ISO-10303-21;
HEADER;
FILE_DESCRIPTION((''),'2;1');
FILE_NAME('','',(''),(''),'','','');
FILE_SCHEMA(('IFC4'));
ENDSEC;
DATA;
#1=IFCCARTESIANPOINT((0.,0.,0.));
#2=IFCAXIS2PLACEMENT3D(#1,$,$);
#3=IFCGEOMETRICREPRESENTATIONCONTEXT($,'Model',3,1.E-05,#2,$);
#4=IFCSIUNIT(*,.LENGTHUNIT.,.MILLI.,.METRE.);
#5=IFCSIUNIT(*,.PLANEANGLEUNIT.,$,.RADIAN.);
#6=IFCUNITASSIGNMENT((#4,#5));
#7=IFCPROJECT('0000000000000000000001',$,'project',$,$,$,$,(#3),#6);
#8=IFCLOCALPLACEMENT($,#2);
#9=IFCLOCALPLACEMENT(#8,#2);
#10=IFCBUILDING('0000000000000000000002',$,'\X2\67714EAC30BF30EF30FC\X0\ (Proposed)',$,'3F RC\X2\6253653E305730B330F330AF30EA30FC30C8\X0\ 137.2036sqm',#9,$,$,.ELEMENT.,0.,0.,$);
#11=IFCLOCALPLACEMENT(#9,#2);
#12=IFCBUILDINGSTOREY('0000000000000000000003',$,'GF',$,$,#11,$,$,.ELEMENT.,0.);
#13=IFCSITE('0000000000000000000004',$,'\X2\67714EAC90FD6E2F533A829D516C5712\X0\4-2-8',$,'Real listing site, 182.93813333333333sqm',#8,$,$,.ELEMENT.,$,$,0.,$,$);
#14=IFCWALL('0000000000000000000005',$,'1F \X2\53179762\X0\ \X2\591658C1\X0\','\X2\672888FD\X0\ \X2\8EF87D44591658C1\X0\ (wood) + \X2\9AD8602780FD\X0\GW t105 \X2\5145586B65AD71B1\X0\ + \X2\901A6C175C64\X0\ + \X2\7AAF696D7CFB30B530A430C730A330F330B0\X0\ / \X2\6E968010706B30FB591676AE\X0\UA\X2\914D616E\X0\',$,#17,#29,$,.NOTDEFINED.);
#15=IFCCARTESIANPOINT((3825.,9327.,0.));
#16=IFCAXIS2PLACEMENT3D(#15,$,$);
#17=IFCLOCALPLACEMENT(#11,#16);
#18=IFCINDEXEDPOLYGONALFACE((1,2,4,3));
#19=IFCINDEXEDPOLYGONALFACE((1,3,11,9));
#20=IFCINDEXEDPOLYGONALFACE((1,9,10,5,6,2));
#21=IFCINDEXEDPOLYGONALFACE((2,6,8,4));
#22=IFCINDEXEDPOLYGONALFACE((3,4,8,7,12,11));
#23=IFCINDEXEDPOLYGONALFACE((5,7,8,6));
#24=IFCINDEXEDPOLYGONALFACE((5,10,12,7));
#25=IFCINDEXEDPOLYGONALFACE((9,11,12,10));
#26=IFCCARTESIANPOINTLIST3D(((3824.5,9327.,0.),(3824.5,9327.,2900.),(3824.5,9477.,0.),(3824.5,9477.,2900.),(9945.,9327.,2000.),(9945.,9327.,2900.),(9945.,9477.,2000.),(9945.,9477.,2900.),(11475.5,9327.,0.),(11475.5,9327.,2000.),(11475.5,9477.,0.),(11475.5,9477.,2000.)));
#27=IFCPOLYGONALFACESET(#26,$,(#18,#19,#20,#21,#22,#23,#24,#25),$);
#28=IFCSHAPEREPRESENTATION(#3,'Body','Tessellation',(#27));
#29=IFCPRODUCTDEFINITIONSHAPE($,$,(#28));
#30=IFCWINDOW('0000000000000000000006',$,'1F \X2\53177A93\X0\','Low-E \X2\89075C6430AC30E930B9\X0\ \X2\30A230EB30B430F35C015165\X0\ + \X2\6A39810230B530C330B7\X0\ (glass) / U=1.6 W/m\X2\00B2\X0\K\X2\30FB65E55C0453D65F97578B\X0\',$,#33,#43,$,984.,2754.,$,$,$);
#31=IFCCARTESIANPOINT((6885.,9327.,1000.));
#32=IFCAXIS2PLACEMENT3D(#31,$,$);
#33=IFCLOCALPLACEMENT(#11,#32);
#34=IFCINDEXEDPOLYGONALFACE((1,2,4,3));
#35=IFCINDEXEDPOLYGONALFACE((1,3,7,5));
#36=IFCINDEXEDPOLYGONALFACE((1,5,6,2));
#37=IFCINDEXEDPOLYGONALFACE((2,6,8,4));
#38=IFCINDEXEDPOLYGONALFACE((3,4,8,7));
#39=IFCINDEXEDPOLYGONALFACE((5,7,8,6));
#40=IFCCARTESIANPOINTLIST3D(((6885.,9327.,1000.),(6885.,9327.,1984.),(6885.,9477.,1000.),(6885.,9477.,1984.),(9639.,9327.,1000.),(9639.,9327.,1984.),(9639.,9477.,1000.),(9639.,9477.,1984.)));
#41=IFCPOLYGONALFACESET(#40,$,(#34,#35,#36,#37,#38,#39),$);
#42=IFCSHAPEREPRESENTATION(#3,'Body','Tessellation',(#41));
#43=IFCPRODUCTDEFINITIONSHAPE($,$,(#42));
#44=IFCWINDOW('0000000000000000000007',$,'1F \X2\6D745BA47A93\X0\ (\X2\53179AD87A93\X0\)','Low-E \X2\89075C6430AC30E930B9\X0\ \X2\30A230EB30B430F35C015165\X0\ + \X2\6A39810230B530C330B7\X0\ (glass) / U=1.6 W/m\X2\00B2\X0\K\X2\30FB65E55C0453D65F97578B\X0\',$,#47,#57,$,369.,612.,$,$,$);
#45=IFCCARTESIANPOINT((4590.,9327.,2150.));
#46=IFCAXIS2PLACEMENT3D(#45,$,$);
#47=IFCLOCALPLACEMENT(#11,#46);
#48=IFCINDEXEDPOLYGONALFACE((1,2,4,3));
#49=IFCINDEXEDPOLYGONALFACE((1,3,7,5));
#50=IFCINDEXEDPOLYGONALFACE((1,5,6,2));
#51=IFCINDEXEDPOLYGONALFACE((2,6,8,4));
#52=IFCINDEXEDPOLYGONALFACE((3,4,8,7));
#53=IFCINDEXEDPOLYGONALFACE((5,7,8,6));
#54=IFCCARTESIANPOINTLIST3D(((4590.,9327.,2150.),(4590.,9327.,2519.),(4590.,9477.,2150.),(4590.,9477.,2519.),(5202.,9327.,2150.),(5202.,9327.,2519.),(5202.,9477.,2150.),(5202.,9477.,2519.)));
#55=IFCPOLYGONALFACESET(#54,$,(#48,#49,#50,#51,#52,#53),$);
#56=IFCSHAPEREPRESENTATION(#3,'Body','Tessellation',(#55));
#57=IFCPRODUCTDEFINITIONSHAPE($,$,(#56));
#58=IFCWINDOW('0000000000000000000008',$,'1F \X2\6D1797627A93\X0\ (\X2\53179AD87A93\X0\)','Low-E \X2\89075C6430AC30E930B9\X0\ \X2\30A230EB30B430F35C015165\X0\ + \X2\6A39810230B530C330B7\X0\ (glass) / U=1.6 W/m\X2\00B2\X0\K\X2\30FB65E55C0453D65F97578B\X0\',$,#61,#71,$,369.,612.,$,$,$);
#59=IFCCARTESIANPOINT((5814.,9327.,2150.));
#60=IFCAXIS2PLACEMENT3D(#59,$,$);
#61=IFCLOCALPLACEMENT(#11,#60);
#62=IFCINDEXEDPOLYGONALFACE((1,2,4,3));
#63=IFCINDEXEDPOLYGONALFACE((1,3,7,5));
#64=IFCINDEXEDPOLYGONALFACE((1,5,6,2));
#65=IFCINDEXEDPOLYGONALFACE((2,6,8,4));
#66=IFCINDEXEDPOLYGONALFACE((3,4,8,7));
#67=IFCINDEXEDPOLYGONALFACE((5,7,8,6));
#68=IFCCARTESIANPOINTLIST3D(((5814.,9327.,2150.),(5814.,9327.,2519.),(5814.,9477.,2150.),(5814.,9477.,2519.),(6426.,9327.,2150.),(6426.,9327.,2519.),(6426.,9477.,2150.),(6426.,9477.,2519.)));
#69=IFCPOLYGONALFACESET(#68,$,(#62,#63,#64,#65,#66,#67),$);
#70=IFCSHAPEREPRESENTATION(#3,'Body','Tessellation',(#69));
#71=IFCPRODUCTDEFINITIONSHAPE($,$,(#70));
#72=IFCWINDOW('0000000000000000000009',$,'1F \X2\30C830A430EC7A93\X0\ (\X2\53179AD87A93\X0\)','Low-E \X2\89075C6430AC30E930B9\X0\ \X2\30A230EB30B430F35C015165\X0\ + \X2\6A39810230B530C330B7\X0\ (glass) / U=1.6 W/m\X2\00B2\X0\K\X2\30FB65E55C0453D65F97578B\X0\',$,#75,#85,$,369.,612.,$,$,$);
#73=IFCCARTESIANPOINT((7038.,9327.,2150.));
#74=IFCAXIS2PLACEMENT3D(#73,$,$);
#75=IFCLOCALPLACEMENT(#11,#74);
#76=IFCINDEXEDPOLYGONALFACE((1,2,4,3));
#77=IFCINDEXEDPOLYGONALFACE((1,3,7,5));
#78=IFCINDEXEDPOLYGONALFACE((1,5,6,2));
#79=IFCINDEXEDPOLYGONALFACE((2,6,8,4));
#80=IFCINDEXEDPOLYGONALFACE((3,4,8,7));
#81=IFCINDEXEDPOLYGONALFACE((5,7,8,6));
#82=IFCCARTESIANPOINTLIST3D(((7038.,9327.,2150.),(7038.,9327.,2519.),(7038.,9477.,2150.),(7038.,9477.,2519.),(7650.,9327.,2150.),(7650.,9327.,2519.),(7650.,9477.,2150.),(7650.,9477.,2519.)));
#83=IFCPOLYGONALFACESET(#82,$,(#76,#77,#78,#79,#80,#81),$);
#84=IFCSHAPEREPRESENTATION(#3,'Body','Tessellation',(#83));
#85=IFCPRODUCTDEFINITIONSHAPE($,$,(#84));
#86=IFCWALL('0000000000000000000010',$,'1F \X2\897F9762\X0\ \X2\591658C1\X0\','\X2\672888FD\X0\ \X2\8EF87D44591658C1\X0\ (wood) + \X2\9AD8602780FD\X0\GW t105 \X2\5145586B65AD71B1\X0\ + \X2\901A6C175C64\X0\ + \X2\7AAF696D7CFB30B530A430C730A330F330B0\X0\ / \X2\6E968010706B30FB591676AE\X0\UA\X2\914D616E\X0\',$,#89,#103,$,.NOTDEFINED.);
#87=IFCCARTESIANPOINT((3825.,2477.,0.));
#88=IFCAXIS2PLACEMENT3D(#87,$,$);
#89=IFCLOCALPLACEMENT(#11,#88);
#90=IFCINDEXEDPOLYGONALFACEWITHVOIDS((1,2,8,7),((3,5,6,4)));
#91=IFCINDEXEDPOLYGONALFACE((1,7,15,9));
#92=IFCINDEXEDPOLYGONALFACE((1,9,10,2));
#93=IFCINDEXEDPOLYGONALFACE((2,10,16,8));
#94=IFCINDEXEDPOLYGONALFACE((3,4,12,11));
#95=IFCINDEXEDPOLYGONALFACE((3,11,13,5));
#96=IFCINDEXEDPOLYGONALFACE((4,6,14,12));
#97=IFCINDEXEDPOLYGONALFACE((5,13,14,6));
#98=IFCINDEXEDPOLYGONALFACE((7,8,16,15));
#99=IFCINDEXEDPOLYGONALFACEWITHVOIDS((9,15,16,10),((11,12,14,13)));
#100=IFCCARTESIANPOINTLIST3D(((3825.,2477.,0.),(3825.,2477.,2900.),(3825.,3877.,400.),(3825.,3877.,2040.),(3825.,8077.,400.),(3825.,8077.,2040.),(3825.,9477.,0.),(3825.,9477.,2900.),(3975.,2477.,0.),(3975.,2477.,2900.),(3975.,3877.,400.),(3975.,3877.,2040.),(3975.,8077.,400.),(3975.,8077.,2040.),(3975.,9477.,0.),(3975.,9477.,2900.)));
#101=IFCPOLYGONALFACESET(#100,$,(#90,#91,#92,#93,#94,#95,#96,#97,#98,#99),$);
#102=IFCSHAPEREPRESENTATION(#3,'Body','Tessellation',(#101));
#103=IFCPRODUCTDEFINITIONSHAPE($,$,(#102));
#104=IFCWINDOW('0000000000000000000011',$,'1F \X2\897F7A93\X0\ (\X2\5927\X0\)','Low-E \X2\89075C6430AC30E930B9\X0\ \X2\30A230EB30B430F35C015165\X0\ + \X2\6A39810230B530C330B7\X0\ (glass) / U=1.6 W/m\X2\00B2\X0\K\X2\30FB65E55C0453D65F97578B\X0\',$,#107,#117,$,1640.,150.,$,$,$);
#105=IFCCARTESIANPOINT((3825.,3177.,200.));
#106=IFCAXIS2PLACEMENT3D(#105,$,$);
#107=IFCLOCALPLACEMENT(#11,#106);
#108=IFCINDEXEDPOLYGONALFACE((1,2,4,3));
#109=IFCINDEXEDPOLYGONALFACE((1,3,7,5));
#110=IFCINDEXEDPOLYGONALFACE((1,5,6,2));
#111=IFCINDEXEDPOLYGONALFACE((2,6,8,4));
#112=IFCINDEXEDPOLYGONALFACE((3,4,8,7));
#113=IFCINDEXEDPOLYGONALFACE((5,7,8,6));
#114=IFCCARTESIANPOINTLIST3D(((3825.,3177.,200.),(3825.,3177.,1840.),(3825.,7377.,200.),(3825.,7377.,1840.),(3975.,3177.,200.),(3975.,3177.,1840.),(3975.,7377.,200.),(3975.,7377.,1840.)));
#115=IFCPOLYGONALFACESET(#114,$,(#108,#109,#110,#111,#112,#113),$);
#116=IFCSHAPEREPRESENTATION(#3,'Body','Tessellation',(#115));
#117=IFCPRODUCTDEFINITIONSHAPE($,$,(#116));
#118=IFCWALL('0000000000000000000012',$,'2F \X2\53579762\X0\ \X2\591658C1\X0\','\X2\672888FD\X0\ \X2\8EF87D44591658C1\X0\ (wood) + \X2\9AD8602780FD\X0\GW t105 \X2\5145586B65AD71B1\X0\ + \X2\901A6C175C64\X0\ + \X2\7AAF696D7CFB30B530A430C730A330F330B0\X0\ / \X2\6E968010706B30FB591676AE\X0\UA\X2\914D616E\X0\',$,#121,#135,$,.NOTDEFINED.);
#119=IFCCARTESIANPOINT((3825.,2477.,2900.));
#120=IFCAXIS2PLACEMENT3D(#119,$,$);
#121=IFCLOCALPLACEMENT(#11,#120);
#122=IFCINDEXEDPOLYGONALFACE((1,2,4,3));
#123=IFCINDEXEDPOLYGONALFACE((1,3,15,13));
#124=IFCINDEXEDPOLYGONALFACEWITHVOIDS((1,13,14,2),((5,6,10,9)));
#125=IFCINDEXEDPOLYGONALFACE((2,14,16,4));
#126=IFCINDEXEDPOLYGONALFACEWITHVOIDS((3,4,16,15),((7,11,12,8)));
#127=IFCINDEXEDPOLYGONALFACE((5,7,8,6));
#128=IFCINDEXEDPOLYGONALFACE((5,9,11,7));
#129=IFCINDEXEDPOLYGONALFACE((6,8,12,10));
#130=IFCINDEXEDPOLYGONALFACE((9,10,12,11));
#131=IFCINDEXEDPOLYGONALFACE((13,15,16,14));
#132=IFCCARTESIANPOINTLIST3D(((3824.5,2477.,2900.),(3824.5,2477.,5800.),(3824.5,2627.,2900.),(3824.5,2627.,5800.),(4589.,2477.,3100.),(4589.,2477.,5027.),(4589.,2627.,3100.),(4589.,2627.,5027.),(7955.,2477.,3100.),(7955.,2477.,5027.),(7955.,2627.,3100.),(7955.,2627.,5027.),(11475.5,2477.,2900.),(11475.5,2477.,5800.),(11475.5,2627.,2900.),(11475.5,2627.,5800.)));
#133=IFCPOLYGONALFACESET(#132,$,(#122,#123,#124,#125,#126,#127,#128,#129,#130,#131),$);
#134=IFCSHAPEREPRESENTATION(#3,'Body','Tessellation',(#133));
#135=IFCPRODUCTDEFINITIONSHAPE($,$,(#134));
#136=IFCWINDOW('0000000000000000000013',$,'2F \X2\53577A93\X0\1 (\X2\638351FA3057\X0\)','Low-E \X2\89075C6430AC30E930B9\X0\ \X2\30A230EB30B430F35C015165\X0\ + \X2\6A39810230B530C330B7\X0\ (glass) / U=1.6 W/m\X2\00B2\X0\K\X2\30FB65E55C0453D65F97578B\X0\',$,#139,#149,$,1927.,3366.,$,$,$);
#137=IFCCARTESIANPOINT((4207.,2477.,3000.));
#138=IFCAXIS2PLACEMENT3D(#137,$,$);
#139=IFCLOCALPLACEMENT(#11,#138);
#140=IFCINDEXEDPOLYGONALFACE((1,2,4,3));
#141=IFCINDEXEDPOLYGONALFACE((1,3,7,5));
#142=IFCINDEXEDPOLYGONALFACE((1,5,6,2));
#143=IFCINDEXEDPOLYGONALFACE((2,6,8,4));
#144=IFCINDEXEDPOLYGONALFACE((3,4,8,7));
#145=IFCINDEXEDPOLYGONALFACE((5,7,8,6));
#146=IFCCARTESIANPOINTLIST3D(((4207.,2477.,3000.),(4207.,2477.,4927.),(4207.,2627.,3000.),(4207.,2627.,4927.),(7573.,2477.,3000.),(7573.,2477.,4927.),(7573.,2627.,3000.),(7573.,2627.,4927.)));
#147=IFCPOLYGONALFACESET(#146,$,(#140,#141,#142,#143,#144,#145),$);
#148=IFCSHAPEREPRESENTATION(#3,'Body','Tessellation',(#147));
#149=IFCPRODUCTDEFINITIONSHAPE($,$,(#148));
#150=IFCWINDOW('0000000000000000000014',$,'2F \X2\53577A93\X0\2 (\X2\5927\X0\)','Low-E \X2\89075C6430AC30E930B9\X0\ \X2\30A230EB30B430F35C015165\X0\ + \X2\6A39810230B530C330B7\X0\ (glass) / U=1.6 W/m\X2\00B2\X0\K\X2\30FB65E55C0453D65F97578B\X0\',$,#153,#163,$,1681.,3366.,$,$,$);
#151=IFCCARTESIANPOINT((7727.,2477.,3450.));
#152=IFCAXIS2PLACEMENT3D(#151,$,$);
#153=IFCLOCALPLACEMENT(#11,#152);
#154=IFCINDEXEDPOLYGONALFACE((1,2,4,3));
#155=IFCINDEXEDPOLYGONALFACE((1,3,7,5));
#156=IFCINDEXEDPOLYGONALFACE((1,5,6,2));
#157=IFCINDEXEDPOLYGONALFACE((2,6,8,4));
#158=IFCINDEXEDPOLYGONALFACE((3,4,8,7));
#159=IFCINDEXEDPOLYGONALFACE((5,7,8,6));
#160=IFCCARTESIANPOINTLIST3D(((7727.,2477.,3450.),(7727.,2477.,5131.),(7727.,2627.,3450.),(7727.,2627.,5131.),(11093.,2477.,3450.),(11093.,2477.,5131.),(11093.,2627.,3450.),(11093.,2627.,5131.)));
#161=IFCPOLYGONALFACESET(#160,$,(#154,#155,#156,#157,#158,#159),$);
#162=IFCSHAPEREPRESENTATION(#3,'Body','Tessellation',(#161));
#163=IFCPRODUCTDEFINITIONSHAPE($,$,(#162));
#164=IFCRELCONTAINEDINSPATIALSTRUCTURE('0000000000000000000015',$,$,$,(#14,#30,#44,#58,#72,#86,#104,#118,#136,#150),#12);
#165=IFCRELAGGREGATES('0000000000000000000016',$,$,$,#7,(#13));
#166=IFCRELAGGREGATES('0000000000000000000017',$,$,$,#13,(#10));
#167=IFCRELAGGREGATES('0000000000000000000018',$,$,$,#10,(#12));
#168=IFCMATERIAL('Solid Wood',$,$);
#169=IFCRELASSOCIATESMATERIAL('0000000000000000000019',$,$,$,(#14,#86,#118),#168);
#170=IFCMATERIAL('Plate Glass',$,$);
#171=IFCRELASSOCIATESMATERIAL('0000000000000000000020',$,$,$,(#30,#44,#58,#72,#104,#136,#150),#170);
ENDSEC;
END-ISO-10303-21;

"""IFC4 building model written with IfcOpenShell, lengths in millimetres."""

from ifc_helpers import new_model, si_unit, frame, frame_2d, origin, place, context, project, spatial, rectangle, extrude, material, element, fill, save


model = new_model("IFC4")

# Units and contexts
model_context = context("Model", 3, precision=1e-05, world=origin())
ifc_project = project(units=[si_unit("LENGTHUNIT", "METRE", prefix="MILLI"), si_unit("PLANEANGLEUNIT", "RADIAN")], contexts=[model_context])

# Site, building, storey
site_placement = place(None, origin())
site = spatial("IfcSite", under=ifc_project, at=site_placement, Name="東京都港区芝公園4-2-8", ObjectType="Real listing site, 182.93813333333333sqm", CompositionType="ELEMENT", RefElevation=0.0)
building_placement = place(site_placement, origin())
building = spatial("IfcBuilding", under=site, at=building_placement, Name="東京タワー (Proposed)", ObjectType="3F RC打放しコンクリート 137.2036sqm", CompositionType="ELEMENT", ElevationOfRefHeight=0.0, ElevationOfTerrain=0.0)
storey_placement = place(building_placement, origin())
storey = spatial("IfcBuildingStorey", under=building, at=storey_placement, Name="GF", CompositionType="ELEMENT", Elevation=0.0)

# Shared definitions
ifc_material_1 = material(Name="Solid Wood")

# Shared definitions
ifc_material_2 = material(Name="Plate Glass")

# Wall, openings, windows
wall_1_placement = place(storey_placement, frame((3825.0, 9327.0, 0.0)))
wall_1 = element("IfcWall", 1, at=wall_1_placement, inside=storey, material=ifc_material_1, Name="1F 北面 外壁", Description="木製 軸組外壁 (wood) + 高性能GW t105 充填断熱 + 通気層 + 窯業系サイディング / 準耐火・外皮UA配慮", PredefinedType="NOTDEFINED", context=model_context, shape_type="SweptSolid", body=[
    extrude(rectangle(XDim=7651.0, YDim=150.0, at=frame_2d((3825.0, 75.0))), frame((3825.0, 9327.0, 0.0)), (0.0, 0.0, 1.0), 2900.0),
])
opening_1_placement = place(storey_placement, frame((6885.0, 9327.0, 1000.0)))
opening_1 = element("IfcOpeningElement", 2, at=opening_1_placement, cuts=wall_1, PredefinedType="NOTDEFINED", context=model_context, shape_type="SweptSolid", body=[
    extrude(rectangle(XDim=2754.0, YDim=150.0, at=frame_2d((1377.0, 75.0))), frame((6885.0, 9327.0, 1000.0)), (0.0, 0.0, 1.0), 984.0),
])
opening_2_placement = place(storey_placement, frame((4590.0, 9327.0, 2150.0)))
opening_2 = element("IfcOpeningElement", 3, at=opening_2_placement, cuts=wall_1, PredefinedType="NOTDEFINED", context=model_context, shape_type="SweptSolid", body=[
    extrude(rectangle(XDim=612.0, YDim=150.0, at=frame_2d((306.0, 75.0))), frame((4590.0, 9327.0, 2150.0)), (0.0, 0.0, 1.0), 369.0),
])
opening_3_placement = place(storey_placement, frame((5814.0, 9327.0, 2150.0)))
opening_3 = element("IfcOpeningElement", 4, at=opening_3_placement, cuts=wall_1, PredefinedType="NOTDEFINED", context=model_context, shape_type="SweptSolid", body=[
    extrude(rectangle(XDim=612.0, YDim=150.0, at=frame_2d((306.0, 75.0))), frame((5814.0, 9327.0, 2150.0)), (0.0, 0.0, 1.0), 369.0),
])
opening_4_placement = place(storey_placement, frame((7038.0, 9327.0, 2150.0)))
opening_4 = element("IfcOpeningElement", 5, at=opening_4_placement, cuts=wall_1, PredefinedType="NOTDEFINED", context=model_context, shape_type="SweptSolid", body=[
    extrude(rectangle(XDim=612.0, YDim=150.0, at=frame_2d((306.0, 75.0))), frame((7038.0, 9327.0, 2150.0)), (0.0, 0.0, 1.0), 369.0),
])
window_1_placement = place(storey_placement, frame((6885.0, 9327.0, 1000.0)))
window_1 = element("IfcWindow", 6, at=window_1_placement, inside=storey, material=ifc_material_2, Name="1F 北窓", Description="Low-E 複層ガラス アルゴン封入 + 樹脂サッシ (glass) / U=1.6 W/m²K・日射取得型", OverallHeight=984.0, OverallWidth=2754.0, context=model_context, shape_type="SweptSolid", body=[
    extrude(rectangle(XDim=2754.0, YDim=150.0, at=frame_2d((1377.0, 75.0))), frame((6885.0, 9327.0, 1000.0)), (0.0, 0.0, 1.0), 984.0),
])
fill(opening_1, window_1)
window_2_placement = place(storey_placement, frame((4590.0, 9327.0, 2150.0)))
window_2 = element("IfcWindow", 7, at=window_2_placement, inside=storey, material=ifc_material_2, Name="1F 浴室窓 (北高窓)", Description="Low-E 複層ガラス アルゴン封入 + 樹脂サッシ (glass) / U=1.6 W/m²K・日射取得型", OverallHeight=369.0, OverallWidth=612.0, context=model_context, shape_type="SweptSolid", body=[
    extrude(rectangle(XDim=612.0, YDim=150.0, at=frame_2d((306.0, 75.0))), frame((4590.0, 9327.0, 2150.0)), (0.0, 0.0, 1.0), 369.0),
])
fill(opening_2, window_2)
window_3_placement = place(storey_placement, frame((5814.0, 9327.0, 2150.0)))
window_3 = element("IfcWindow", 8, at=window_3_placement, inside=storey, material=ifc_material_2, Name="1F 洗面窓 (北高窓)", Description="Low-E 複層ガラス アルゴン封入 + 樹脂サッシ (glass) / U=1.6 W/m²K・日射取得型", OverallHeight=369.0, OverallWidth=612.0, context=model_context, shape_type="SweptSolid", body=[
    extrude(rectangle(XDim=612.0, YDim=150.0, at=frame_2d((306.0, 75.0))), frame((5814.0, 9327.0, 2150.0)), (0.0, 0.0, 1.0), 369.0),
])
fill(opening_3, window_3)
window_4_placement = place(storey_placement, frame((7038.0, 9327.0, 2150.0)))
window_4 = element("IfcWindow", 9, at=window_4_placement, inside=storey, material=ifc_material_2, Name="1F トイレ窓 (北高窓)", Description="Low-E 複層ガラス アルゴン封入 + 樹脂サッシ (glass) / U=1.6 W/m²K・日射取得型", OverallHeight=369.0, OverallWidth=612.0, context=model_context, shape_type="SweptSolid", body=[
    extrude(rectangle(XDim=612.0, YDim=150.0, at=frame_2d((306.0, 75.0))), frame((7038.0, 9327.0, 2150.0)), (0.0, 0.0, 1.0), 369.0),
])
fill(opening_4, window_4)

# Wall, opening, window
wall_2_placement = place(storey_placement, frame((3825.0, 2477.0, 0.0)))
wall_2 = element("IfcWall", 10, at=wall_2_placement, inside=storey, material=ifc_material_1, Name="1F 西面 外壁", Description="木製 軸組外壁 (wood) + 高性能GW t105 充填断熱 + 通気層 + 窯業系サイディング / 準耐火・外皮UA配慮", PredefinedType="NOTDEFINED", context=model_context, shape_type="SweptSolid", body=[
    extrude(rectangle(XDim=150.0, YDim=7000.0, at=frame_2d((75.0, 3500.0))), frame((3825.0, 2477.0, 0.0)), (0.0, 0.0, 1.0), 2900.0),
])
opening_5_placement = place(storey_placement, frame((3825.0, 3177.0, 200.0)))
opening_5 = element("IfcOpeningElement", 11, at=opening_5_placement, cuts=wall_2, PredefinedType="NOTDEFINED", context=model_context, shape_type="SweptSolid", body=[
    extrude(rectangle(XDim=150.0, YDim=4200.0, at=frame_2d((75.0, 2100.0))), frame((3825.0, 3177.0, 200.0)), (0.0, 0.0, 1.0), 1640.0),
])
window_5_placement = place(storey_placement, frame((3825.0, 3177.0, 200.0)))
window_5 = element("IfcWindow", 12, at=window_5_placement, inside=storey, material=ifc_material_2, Name="1F 西窓 (大)", Description="Low-E 複層ガラス アルゴン封入 + 樹脂サッシ (glass) / U=1.6 W/m²K・日射取得型", OverallHeight=1640.0, OverallWidth=150.0, context=model_context, shape_type="SweptSolid", body=[
    extrude(rectangle(XDim=150.0, YDim=4200.0, at=frame_2d((75.0, 2100.0))), frame((3825.0, 3177.0, 200.0)), (0.0, 0.0, 1.0), 1640.0),
])
fill(opening_5, window_5)

# Wall, openings, windows
wall_3_placement = place(storey_placement, frame((3825.0, 2477.0, 2900.0)))
wall_3 = element("IfcWall", 13, at=wall_3_placement, inside=storey, material=ifc_material_1, Name="2F 南面 外壁", Description="木製 軸組外壁 (wood) + 高性能GW t105 充填断熱 + 通気層 + 窯業系サイディング / 準耐火・外皮UA配慮", PredefinedType="NOTDEFINED", context=model_context, shape_type="SweptSolid", body=[
    extrude(rectangle(XDim=7651.0, YDim=150.0, at=frame_2d((3825.0, 75.0))), frame((3825.0, 2477.0, 2900.0)), (0.0, 0.0, 1.0), 2900.0),
])
opening_6_placement = place(storey_placement, frame((4207.0, 2477.0, 3000.0)))
opening_6 = element("IfcOpeningElement", 14, at=opening_6_placement, cuts=wall_3, PredefinedType="NOTDEFINED", context=model_context, shape_type="SweptSolid", body=[
    extrude(rectangle(XDim=3366.0, YDim=150.0, at=frame_2d((1683.0, 75.0))), frame((4207.0, 2477.0, 3000.0)), (0.0, 0.0, 1.0), 1927.0),
])
opening_7_placement = place(storey_placement, frame((7727.0, 2477.0, 3450.0)))
opening_7 = element("IfcOpeningElement", 15, at=opening_7_placement, cuts=wall_3, PredefinedType="NOTDEFINED", context=model_context, shape_type="SweptSolid", body=[
    extrude(rectangle(XDim=3366.0, YDim=150.0, at=frame_2d((1683.0, 75.0))), frame((7727.0, 2477.0, 3450.0)), (0.0, 0.0, 1.0), 1681.0),
])
window_6_placement = place(storey_placement, frame((4207.0, 2477.0, 3000.0)))
window_6 = element("IfcWindow", 16, at=window_6_placement, inside=storey, material=ifc_material_2, Name="2F 南窓1 (掃出し)", Description="Low-E 複層ガラス アルゴン封入 + 樹脂サッシ (glass) / U=1.6 W/m²K・日射取得型", OverallHeight=1927.0, OverallWidth=3366.0, context=model_context, shape_type="SweptSolid", body=[
    extrude(rectangle(XDim=3366.0, YDim=150.0, at=frame_2d((1683.0, 75.0))), frame((4207.0, 2477.0, 3000.0)), (0.0, 0.0, 1.0), 1927.0),
])
fill(opening_6, window_6)
window_7_placement = place(storey_placement, frame((7727.0, 2477.0, 3450.0)))
window_7 = element("IfcWindow", 17, at=window_7_placement, inside=storey, material=ifc_material_2, Name="2F 南窓2 (大)", Description="Low-E 複層ガラス アルゴン封入 + 樹脂サッシ (glass) / U=1.6 W/m²K・日射取得型", OverallHeight=1681.0, OverallWidth=3366.0, context=model_context, shape_type="SweptSolid", body=[
    extrude(rectangle(XDim=3366.0, YDim=150.0, at=frame_2d((1683.0, 75.0))), frame((7727.0, 2477.0, 3450.0)), (0.0, 0.0, 1.0), 1681.0),
])
fill(opening_7, window_7)

save(model, "model.ifc")
